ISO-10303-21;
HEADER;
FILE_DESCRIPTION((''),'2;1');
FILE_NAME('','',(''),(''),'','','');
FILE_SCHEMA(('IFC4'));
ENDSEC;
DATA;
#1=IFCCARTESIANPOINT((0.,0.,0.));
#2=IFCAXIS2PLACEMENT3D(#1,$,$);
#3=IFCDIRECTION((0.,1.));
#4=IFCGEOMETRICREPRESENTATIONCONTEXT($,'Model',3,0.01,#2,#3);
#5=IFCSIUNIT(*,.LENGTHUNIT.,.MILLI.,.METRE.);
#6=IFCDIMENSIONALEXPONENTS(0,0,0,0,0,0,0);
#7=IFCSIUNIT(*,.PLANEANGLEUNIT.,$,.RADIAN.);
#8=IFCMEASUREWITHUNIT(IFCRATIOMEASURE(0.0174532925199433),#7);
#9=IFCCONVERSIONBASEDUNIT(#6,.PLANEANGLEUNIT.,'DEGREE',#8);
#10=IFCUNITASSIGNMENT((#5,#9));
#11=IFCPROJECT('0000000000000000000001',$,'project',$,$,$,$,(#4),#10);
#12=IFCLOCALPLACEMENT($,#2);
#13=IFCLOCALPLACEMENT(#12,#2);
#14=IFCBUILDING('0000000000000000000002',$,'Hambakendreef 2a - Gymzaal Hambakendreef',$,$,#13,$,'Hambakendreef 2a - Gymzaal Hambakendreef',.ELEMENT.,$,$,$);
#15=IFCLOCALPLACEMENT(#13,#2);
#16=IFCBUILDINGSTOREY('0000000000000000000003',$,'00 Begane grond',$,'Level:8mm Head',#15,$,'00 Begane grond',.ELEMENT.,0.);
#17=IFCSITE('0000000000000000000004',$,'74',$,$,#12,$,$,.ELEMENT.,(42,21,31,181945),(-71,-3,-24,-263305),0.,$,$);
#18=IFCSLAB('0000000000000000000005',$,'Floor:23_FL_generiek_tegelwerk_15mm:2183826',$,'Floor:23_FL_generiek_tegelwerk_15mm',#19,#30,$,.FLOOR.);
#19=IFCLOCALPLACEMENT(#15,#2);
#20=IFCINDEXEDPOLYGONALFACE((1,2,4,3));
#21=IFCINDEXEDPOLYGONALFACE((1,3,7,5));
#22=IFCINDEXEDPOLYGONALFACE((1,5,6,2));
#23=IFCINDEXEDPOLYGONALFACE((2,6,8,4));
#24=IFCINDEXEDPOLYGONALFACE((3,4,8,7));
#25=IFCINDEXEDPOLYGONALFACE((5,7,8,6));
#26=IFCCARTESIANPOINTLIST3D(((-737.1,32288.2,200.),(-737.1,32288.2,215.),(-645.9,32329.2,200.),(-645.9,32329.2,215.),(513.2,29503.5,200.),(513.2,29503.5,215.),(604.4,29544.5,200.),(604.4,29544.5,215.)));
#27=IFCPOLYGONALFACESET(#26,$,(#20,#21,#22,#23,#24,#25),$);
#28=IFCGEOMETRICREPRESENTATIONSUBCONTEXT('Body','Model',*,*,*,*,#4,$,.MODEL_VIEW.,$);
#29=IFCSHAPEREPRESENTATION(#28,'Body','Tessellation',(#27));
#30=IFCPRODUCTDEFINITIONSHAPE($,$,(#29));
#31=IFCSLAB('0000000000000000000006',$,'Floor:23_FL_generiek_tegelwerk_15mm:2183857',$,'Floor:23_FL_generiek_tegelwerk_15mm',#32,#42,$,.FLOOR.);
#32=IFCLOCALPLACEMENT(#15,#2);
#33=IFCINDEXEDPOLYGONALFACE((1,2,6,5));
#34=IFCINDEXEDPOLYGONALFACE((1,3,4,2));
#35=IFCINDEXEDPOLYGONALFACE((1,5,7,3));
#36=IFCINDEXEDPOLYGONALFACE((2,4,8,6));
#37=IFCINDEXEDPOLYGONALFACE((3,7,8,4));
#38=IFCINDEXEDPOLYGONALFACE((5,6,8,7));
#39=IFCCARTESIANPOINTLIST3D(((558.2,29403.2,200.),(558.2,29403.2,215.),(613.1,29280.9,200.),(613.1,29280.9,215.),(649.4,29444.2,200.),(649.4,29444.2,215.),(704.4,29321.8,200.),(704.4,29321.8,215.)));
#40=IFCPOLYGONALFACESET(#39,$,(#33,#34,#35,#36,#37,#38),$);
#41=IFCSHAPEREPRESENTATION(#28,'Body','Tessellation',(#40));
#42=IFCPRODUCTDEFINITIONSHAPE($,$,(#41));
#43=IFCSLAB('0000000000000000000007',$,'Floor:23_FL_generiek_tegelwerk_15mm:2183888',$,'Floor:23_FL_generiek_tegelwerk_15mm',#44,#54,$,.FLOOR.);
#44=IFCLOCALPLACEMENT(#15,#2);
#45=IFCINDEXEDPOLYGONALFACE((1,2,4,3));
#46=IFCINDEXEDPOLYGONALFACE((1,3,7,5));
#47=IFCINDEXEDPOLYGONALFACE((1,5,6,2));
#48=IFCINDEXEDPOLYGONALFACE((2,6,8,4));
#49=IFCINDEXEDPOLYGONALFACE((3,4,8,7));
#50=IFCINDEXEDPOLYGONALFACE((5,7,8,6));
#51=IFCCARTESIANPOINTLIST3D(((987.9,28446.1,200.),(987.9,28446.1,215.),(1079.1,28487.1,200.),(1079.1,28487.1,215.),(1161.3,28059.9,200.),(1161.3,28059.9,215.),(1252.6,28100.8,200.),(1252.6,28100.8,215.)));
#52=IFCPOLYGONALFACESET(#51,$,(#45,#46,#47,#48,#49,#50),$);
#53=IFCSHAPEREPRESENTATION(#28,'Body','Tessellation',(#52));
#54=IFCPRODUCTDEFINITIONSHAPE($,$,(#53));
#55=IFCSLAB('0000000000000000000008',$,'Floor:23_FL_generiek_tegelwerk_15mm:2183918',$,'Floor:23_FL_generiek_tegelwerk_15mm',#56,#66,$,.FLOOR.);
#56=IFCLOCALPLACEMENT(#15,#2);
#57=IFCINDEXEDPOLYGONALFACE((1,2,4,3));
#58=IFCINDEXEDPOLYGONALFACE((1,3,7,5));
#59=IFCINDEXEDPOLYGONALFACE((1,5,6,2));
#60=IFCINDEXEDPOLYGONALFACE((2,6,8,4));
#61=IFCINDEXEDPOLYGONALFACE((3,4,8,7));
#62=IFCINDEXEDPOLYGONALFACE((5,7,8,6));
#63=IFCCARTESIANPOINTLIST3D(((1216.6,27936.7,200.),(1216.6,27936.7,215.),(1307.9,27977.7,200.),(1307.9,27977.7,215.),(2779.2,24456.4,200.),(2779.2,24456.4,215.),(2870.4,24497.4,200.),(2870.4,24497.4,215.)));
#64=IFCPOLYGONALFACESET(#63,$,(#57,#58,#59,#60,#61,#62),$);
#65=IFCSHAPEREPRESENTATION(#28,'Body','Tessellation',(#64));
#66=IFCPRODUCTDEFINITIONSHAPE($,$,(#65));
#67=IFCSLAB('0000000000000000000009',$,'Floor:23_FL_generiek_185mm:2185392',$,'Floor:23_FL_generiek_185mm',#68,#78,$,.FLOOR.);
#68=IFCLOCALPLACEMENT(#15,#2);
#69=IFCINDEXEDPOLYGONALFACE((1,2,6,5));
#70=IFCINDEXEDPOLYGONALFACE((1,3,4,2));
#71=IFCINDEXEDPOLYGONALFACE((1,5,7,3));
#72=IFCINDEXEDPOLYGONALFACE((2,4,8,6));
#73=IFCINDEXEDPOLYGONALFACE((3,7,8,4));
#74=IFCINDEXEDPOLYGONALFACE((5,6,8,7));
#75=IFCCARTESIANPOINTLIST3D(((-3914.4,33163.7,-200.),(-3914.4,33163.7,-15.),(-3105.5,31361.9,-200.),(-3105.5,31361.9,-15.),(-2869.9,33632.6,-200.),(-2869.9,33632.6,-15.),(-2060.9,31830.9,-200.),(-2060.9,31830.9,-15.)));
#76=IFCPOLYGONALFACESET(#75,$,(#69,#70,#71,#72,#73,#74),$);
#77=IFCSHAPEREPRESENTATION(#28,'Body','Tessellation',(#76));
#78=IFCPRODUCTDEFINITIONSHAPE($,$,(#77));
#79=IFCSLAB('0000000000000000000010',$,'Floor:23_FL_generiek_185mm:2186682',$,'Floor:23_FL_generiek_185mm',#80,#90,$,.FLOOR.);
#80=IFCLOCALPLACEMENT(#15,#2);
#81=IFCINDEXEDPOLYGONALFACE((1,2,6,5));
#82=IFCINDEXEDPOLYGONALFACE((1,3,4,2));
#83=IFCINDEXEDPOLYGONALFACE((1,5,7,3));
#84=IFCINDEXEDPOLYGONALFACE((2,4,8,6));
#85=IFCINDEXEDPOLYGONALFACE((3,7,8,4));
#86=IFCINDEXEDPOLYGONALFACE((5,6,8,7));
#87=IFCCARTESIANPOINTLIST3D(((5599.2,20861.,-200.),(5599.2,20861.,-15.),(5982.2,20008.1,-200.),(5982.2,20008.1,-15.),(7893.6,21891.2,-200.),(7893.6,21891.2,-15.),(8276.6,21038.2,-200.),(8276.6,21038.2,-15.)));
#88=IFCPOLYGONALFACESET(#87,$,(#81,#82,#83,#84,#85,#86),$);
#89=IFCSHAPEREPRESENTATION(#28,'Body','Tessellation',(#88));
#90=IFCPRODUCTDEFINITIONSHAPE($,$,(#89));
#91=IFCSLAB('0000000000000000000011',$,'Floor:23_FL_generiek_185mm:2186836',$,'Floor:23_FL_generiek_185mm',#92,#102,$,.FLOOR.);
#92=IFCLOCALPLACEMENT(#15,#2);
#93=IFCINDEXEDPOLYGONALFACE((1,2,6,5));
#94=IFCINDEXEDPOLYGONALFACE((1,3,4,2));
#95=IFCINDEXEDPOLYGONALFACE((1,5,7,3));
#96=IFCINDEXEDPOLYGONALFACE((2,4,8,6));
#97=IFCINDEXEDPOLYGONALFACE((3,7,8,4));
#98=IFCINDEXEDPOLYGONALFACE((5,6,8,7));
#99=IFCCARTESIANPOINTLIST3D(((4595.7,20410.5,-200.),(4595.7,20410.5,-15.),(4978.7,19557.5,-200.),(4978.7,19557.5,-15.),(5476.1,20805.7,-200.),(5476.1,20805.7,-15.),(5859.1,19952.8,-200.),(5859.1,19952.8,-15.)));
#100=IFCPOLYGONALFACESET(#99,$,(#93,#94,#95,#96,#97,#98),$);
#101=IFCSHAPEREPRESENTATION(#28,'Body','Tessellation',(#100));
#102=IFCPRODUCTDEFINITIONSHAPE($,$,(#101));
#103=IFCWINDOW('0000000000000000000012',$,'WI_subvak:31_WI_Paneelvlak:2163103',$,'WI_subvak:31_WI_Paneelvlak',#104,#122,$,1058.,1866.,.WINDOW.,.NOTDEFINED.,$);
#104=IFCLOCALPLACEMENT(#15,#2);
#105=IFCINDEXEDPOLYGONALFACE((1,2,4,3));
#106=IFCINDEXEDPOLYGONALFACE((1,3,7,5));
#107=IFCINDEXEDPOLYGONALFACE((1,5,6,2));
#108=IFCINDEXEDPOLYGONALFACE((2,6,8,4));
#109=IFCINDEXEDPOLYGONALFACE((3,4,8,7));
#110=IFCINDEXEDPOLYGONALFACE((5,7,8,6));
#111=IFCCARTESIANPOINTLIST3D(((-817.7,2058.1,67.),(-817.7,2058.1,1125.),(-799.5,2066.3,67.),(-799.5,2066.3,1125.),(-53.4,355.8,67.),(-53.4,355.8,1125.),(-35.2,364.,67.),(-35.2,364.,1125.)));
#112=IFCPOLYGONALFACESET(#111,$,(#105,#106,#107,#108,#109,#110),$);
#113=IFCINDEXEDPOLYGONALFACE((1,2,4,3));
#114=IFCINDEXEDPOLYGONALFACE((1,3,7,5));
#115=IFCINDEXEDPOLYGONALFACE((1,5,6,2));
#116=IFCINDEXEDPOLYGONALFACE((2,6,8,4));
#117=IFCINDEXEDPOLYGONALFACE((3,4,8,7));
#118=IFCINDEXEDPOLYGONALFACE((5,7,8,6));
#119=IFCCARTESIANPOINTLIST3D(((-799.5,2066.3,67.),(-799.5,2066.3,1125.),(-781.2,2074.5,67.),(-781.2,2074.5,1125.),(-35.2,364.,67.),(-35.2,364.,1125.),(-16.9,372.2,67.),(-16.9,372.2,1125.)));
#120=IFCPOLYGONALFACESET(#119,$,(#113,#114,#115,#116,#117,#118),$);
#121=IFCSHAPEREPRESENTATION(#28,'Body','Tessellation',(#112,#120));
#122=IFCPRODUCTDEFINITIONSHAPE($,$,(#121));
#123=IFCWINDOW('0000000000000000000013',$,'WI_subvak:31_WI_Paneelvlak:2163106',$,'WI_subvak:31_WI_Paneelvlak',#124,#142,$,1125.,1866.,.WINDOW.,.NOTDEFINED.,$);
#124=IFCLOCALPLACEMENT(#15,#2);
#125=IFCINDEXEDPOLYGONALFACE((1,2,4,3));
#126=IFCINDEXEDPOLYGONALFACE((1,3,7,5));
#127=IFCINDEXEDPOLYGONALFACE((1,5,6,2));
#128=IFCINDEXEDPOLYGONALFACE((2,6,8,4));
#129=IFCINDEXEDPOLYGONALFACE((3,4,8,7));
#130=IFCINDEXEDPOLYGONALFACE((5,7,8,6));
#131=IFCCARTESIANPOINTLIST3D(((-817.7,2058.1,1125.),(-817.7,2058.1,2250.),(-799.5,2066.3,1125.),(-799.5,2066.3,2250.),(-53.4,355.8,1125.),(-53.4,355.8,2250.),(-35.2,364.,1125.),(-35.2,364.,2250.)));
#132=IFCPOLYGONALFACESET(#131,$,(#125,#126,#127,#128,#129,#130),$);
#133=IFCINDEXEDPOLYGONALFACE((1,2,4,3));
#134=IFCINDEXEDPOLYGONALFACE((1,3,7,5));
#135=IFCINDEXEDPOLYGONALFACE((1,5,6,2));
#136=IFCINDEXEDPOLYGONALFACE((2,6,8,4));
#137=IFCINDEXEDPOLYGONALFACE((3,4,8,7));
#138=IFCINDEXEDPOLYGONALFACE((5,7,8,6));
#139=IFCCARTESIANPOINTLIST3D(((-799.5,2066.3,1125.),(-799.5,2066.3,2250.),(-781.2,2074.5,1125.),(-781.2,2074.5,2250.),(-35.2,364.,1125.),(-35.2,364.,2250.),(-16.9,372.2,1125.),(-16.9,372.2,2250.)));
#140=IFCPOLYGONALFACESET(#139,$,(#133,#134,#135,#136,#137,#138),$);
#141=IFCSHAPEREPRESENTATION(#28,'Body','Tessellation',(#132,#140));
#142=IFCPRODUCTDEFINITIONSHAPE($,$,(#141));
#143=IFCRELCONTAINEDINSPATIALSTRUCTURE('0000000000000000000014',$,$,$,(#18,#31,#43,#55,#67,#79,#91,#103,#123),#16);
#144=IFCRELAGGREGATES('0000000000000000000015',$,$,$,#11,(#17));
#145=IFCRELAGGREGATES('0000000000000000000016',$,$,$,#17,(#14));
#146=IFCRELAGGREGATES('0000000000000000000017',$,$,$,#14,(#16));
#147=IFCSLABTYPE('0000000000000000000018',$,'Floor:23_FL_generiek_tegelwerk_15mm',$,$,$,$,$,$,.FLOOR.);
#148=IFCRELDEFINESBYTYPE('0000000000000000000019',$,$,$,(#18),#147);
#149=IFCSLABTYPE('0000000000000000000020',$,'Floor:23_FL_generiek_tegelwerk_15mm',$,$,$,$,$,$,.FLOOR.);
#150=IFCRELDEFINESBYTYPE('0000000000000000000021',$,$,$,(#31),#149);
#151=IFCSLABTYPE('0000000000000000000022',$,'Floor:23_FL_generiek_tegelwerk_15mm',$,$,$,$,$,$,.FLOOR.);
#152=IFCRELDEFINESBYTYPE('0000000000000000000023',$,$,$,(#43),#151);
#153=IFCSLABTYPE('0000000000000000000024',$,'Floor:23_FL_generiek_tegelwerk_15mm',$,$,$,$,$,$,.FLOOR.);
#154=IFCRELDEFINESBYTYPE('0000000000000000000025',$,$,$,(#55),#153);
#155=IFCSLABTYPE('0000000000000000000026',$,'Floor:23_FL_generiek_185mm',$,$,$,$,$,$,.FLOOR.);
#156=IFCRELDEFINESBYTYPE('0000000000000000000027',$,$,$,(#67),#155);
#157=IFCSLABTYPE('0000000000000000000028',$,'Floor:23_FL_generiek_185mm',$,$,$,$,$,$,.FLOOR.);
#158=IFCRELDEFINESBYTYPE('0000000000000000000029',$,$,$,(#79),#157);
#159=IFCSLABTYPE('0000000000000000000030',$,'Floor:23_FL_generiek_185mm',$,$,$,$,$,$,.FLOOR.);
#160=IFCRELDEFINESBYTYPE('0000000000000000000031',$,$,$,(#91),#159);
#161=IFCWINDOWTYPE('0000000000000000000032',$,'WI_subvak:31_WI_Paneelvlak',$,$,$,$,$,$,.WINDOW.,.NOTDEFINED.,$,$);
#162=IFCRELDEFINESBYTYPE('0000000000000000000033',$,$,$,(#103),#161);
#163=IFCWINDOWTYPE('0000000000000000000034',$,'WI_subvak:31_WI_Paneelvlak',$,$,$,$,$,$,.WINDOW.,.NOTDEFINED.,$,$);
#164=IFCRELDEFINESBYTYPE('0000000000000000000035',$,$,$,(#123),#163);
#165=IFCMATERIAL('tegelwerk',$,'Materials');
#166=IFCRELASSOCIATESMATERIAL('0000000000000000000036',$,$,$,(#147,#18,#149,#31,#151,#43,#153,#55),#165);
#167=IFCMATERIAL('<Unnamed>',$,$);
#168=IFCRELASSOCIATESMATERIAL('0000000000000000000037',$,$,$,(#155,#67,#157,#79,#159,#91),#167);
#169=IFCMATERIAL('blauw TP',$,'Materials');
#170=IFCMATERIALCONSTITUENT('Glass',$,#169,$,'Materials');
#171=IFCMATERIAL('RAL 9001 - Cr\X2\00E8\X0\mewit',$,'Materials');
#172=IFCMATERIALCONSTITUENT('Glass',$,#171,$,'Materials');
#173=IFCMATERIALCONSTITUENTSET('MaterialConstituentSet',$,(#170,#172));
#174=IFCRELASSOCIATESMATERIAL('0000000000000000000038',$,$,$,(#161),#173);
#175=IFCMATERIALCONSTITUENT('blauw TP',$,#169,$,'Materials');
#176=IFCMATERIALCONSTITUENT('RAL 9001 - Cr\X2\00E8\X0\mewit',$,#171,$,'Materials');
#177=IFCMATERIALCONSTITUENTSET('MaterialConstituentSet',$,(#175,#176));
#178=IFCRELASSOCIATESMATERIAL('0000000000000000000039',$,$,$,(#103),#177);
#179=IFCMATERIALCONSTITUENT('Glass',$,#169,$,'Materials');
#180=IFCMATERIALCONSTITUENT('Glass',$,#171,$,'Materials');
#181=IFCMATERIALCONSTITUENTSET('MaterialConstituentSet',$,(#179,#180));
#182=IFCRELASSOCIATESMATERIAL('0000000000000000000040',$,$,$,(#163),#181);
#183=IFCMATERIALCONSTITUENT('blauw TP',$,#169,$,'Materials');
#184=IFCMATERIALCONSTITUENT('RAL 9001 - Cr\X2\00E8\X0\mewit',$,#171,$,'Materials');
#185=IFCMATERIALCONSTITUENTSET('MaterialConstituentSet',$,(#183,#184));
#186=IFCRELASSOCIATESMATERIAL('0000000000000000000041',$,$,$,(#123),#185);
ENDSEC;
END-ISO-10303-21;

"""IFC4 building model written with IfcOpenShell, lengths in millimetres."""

from ifc_helpers import new_model, entity, si_unit, converted_unit, direction, frame, origin, place, context, subcontext, project, spatial, indexed_curve, outline, extrude, source, transform, mapped, material, constituent, constituent_set, type_object, type_shapes, element, save


model = new_model("IFC4")

# Units and contexts
model_context = context("Model", 3, precision=0.01, world=origin(), true_north=direction((0.0, 1.0)))
body_context = subcontext(model_context, "Body", "Model", "MODEL_VIEW")
ifc_project = project(units=[si_unit("LENGTHUNIT", "METRE", prefix="MILLI"), converted_unit("PLANEANGLEUNIT", "DEGREE", entity("IfcRatioMeasure", 0.0174532925199433), si_unit("PLANEANGLEUNIT", "RADIAN"), dimensions=[0, 0, 0, 0, 0, 0, 0])], contexts=[model_context])

# Site, building, storey
site_placement = place(None, origin())
site = spatial("IfcSite", under=ifc_project, at=site_placement, Name="74", CompositionType="ELEMENT", RefLatitude=(42, 21, 31, 181945), RefLongitude=(-71, -3, -24, -263305), RefElevation=0.0)
building_placement = place(site_placement, origin())
building = spatial("IfcBuilding", under=site, at=building_placement, Name="Hambakendreef 2a - Gymzaal Hambakendreef", LongName="Hambakendreef 2a - Gymzaal Hambakendreef", CompositionType="ELEMENT")
storey_placement = place(building_placement, origin())
storey = spatial("IfcBuildingStorey", under=building, at=storey_placement, Name="00 Begane grond", ObjectType="Level:8mm Head", LongName="00 Begane grond", CompositionType="ELEMENT", Elevation=0.0)

# Shared definitions
ifc_material_1 = material(Name="<Unnamed>")

# Slabs
ifc_material_2 = material(Name="tegelwerk", Category="Materials")
slab_type_1 = type_object("IfcSlabType", Name="Floor:23_FL_generiek_tegelwerk_15mm", PredefinedType="FLOOR", material=ifc_material_2)
slab_1_placement = place(storey_placement, origin())
element("IfcSlab", 1, at=slab_1_placement, inside=storey, type_object=slab_type_1, material=ifc_material_2, Name="Floor:23_FL_generiek_tegelwerk_15mm:2183826", ObjectType="Floor:23_FL_generiek_tegelwerk_15mm", PredefinedType="FLOOR", context=body_context, shape_type="SweptSolid", body=[
    extrude(outline(indexed_curve([(-1526.3, -50.0), (1526.3, -50.0), (1526.3, 50.0), (-1526.3, 50.0), (-1526.3, -50.0)], self_intersect=False)), frame((-66.4, 30916.4, 215.0), z_axis=(0.0, 0.0, -1.0), x_axis=(0.40959, -0.91227, 0.0)), (0.0, 0.0, 1.0), 15.0),
])
slab_type_2 = type_object("IfcSlabType", Name="Floor:23_FL_generiek_tegelwerk_15mm", PredefinedType="FLOOR", material=ifc_material_2)
slab_2_placement = place(storey_placement, origin())
element("IfcSlab", 2, at=slab_2_placement, inside=storey, type_object=slab_type_2, material=ifc_material_2, Name="Floor:23_FL_generiek_tegelwerk_15mm:2183857", ObjectType="Floor:23_FL_generiek_tegelwerk_15mm", PredefinedType="FLOOR", context=body_context, shape_type="SweptSolid", body=[
    extrude(outline(indexed_curve([(-67.0, -50.0), (67.0, -50.0), (67.0, 50.0), (-67.0, 50.0), (-67.0, -50.0)], self_intersect=False)), frame((631.3, 29362.5, 215.0), z_axis=(0.0, 0.0, -1.0), x_axis=(0.40959, -0.91227, 0.0)), (0.0, 0.0, 1.0), 15.0),
])
slab_type_3 = type_object("IfcSlabType", Name="Floor:23_FL_generiek_tegelwerk_15mm", PredefinedType="FLOOR", material=ifc_material_2)
slab_3_placement = place(storey_placement, origin())
element("IfcSlab", 3, at=slab_3_placement, inside=storey, type_object=slab_type_3, material=ifc_material_2, Name="Floor:23_FL_generiek_tegelwerk_15mm:2183888", ObjectType="Floor:23_FL_generiek_tegelwerk_15mm", PredefinedType="FLOOR", context=body_context, shape_type="SweptSolid", body=[
    extrude(outline(indexed_curve([(-211.7, -50.0), (211.7, -50.0), (211.7, 50.0), (-211.7, 50.0), (-211.7, -50.0)], self_intersect=False)), frame((1120.2, 28273.5, 215.0), z_axis=(0.0, 0.0, -1.0), x_axis=(0.40959, -0.91227, 0.0)), (0.0, 0.0, 1.0), 15.0),
])
slab_type_4 = type_object("IfcSlabType", Name="Floor:23_FL_generiek_tegelwerk_15mm", PredefinedType="FLOOR", material=ifc_material_2)
slab_4_placement = place(storey_placement, origin())
element("IfcSlab", 4, at=slab_4_placement, inside=storey, type_object=slab_type_4, material=ifc_material_2, Name="Floor:23_FL_generiek_tegelwerk_15mm:2183918", ObjectType="Floor:23_FL_generiek_tegelwerk_15mm", PredefinedType="FLOOR", context=body_context, shape_type="SweptSolid", body=[
    extrude(outline(indexed_curve([(-1907.5, -50.0), (1907.5, -50.0), (1907.5, 50.0), (-1907.5, 50.0), (-1907.5, -50.0)], self_intersect=False)), frame((2043.5, 26217.0, 215.0), z_axis=(0.0, 0.0, -1.0), x_axis=(0.40959, -0.91227, 0.0)), (0.0, 0.0, 1.0), 15.0),
])
slab_type_5 = type_object("IfcSlabType", Name="Floor:23_FL_generiek_185mm", PredefinedType="FLOOR", material=ifc_material_1)
slab_5_placement = place(storey_placement, origin())
element("IfcSlab", 5, at=slab_5_placement, inside=storey, type_object=slab_type_5, material=ifc_material_1, Name="Floor:23_FL_generiek_185mm:2185392", ObjectType="Floor:23_FL_generiek_185mm", PredefinedType="FLOOR", context=body_context, shape_type="SweptSolid", body=[
    extrude(outline(indexed_curve([(-987.5, -572.5), (987.5, -572.5), (987.5, 572.5), (-987.5, 572.5), (-987.5, -572.5)], self_intersect=False)), frame((-2987.7, 32497.3, -15.0), z_axis=(0.0, 0.0, -1.0), x_axis=(0.40959, -0.91227, 0.0)), (0.0, 0.0, 1.0), 185.0),
])
slab_type_6 = type_object("IfcSlabType", Name="Floor:23_FL_generiek_185mm", PredefinedType="FLOOR", material=ifc_material_1)
slab_6_placement = place(storey_placement, origin())
element("IfcSlab", 6, at=slab_6_placement, inside=storey, type_object=slab_type_6, material=ifc_material_1, Name="Floor:23_FL_generiek_185mm:2186682", ObjectType="Floor:23_FL_generiek_185mm", PredefinedType="FLOOR", context=body_context, shape_type="SweptSolid", body=[
    extrude(outline(indexed_curve([(-467.5, -1257.5), (467.5, -1257.5), (467.5, 1257.5), (-467.5, 1257.5), (-467.5, -1257.5)], self_intersect=False)), frame((6937.9, 20949.6, -15.0), z_axis=(0.0, 0.0, -1.0), x_axis=(0.40959, -0.91227, 0.0)), (0.0, 0.0, 1.0), 185.0),
])
slab_type_7 = type_object("IfcSlabType", Name="Floor:23_FL_generiek_185mm", PredefinedType="FLOOR", material=ifc_material_1)
slab_7_placement = place(storey_placement, origin())
element("IfcSlab", 7, at=slab_7_placement, inside=storey, type_object=slab_type_7, material=ifc_material_1, Name="Floor:23_FL_generiek_185mm:2186836", ObjectType="Floor:23_FL_generiek_185mm", PredefinedType="FLOOR", context=body_context, shape_type="SweptSolid", body=[
    extrude(outline(indexed_curve([(-467.5, -482.5), (467.5, -482.5), (467.5, 482.5), (-467.5, 482.5), (-467.5, -482.5)], self_intersect=False)), frame((5227.4, 20181.6, -15.0), z_axis=(0.0, 0.0, -1.0), x_axis=(0.40959, -0.91227, 0.0)), (0.0, 0.0, 1.0), 185.0),
])

# Windows
ifc_material_3 = material(Name="blauw TP", Category="Materials")
ifc_constituent_1 = constituent(ifc_material_3, Name="blauw TP", Category="Materials")
ifc_material_4 = material(Name="RAL 9001 - Crèmewit", Category="Materials")
ifc_constituent_2 = constituent(ifc_material_4, Name="RAL 9001 - Crèmewit", Category="Materials")
ifc_constituent_set_1 = constituent_set(constituents=[ifc_constituent_1, ifc_constituent_2], Name="MaterialConstituentSet")
ifc_constituent_3 = constituent(ifc_material_3, Name="Glass", Category="Materials")
ifc_constituent_4 = constituent(ifc_material_4, Name="Glass", Category="Materials")
ifc_constituent_set_2 = constituent_set(constituents=[ifc_constituent_3, ifc_constituent_4], Name="MaterialConstituentSet")
window_type_1 = type_object("IfcWindowType", Name="WI_subvak:31_WI_Paneelvlak", PartitioningType="NOTDEFINED", PredefinedType="WINDOW", material=ifc_constituent_set_2)
shared_shape_1 = source(origin(), body_context, "Body", "SweptSolid", [
    extrude(outline(indexed_curve([(-933.0, -10.0), (933.0, -10.0), (933.0, 10.0), (-933.0, 10.0), (-933.0, -10.0)], self_intersect=False)), frame((0.0, -10.0, 0.0)), (0.0, 0.0, 1.0), 1058.0),
    extrude(outline(indexed_curve([(-933.0, -10.0), (933.0, -10.0), (933.0, 10.0), (-933.0, 10.0), (-933.0, -10.0)], self_intersect=False)), frame((0.0, 10.0, 0.0)), (0.0, 0.0, 1.0), 1058.0),
])
type_shapes(window_type_1, [shared_shape_1])
window_1_placement = place(storey_placement, frame((-417.3, 1215.2, 67.0), z_axis=(0.0, 0.0, 1.0), x_axis=(0.40959, -0.91227, 0.0)))
element("IfcWindow", 8, at=window_1_placement, inside=storey, type_object=window_type_1, material=ifc_constituent_set_1, Name="WI_subvak:31_WI_Paneelvlak:2163103", ObjectType="WI_subvak:31_WI_Paneelvlak", OverallHeight=1058.0, OverallWidth=1866.0, PartitioningType="NOTDEFINED", PredefinedType="WINDOW", context=body_context, shape_type="MappedRepresentation", body=[
    mapped(shared_shape_1, transform((0.0, 0.0, 0.0), scale=1.0)),
])
ifc_constituent_5 = constituent(ifc_material_3, Name="blauw TP", Category="Materials")
ifc_constituent_6 = constituent(ifc_material_4, Name="RAL 9001 - Crèmewit", Category="Materials")
ifc_constituent_set_3 = constituent_set(constituents=[ifc_constituent_5, ifc_constituent_6], Name="MaterialConstituentSet")
ifc_constituent_7 = constituent(ifc_material_3, Name="Glass", Category="Materials")
ifc_constituent_8 = constituent(ifc_material_4, Name="Glass", Category="Materials")
ifc_constituent_set_4 = constituent_set(constituents=[ifc_constituent_7, ifc_constituent_8], Name="MaterialConstituentSet")
window_type_2 = type_object("IfcWindowType", Name="WI_subvak:31_WI_Paneelvlak", PartitioningType="NOTDEFINED", PredefinedType="WINDOW", material=ifc_constituent_set_4)
shared_shape_2 = source(origin(), body_context, "Body", "SweptSolid", [
    extrude(outline(indexed_curve([(-933.0, -10.0), (933.0, -10.0), (933.0, 10.0), (-933.0, 10.0), (-933.0, -10.0)], self_intersect=False)), frame((0.0, -10.0, 0.0)), (0.0, 0.0, 1.0), 1125.0),
    extrude(outline(indexed_curve([(-933.0, -10.0), (933.0, -10.0), (933.0, 10.0), (-933.0, 10.0), (-933.0, -10.0)], self_intersect=False)), frame((0.0, 10.0, 0.0)), (0.0, 0.0, 1.0), 1125.0),
])
type_shapes(window_type_2, [shared_shape_2])
window_2_placement = place(storey_placement, frame((-417.3, 1215.2, 1125.0), z_axis=(0.0, 0.0, 1.0), x_axis=(0.40959, -0.91227, 0.0)))
element("IfcWindow", 9, at=window_2_placement, inside=storey, type_object=window_type_2, material=ifc_constituent_set_3, Name="WI_subvak:31_WI_Paneelvlak:2163106", ObjectType="WI_subvak:31_WI_Paneelvlak", OverallHeight=1125.0, OverallWidth=1866.0, PartitioningType="NOTDEFINED", PredefinedType="WINDOW", context=body_context, shape_type="MappedRepresentation", body=[
    mapped(shared_shape_2, transform((0.0, 0.0, 0.0), scale=1.0)),
])

save(model, "model.ifc")
